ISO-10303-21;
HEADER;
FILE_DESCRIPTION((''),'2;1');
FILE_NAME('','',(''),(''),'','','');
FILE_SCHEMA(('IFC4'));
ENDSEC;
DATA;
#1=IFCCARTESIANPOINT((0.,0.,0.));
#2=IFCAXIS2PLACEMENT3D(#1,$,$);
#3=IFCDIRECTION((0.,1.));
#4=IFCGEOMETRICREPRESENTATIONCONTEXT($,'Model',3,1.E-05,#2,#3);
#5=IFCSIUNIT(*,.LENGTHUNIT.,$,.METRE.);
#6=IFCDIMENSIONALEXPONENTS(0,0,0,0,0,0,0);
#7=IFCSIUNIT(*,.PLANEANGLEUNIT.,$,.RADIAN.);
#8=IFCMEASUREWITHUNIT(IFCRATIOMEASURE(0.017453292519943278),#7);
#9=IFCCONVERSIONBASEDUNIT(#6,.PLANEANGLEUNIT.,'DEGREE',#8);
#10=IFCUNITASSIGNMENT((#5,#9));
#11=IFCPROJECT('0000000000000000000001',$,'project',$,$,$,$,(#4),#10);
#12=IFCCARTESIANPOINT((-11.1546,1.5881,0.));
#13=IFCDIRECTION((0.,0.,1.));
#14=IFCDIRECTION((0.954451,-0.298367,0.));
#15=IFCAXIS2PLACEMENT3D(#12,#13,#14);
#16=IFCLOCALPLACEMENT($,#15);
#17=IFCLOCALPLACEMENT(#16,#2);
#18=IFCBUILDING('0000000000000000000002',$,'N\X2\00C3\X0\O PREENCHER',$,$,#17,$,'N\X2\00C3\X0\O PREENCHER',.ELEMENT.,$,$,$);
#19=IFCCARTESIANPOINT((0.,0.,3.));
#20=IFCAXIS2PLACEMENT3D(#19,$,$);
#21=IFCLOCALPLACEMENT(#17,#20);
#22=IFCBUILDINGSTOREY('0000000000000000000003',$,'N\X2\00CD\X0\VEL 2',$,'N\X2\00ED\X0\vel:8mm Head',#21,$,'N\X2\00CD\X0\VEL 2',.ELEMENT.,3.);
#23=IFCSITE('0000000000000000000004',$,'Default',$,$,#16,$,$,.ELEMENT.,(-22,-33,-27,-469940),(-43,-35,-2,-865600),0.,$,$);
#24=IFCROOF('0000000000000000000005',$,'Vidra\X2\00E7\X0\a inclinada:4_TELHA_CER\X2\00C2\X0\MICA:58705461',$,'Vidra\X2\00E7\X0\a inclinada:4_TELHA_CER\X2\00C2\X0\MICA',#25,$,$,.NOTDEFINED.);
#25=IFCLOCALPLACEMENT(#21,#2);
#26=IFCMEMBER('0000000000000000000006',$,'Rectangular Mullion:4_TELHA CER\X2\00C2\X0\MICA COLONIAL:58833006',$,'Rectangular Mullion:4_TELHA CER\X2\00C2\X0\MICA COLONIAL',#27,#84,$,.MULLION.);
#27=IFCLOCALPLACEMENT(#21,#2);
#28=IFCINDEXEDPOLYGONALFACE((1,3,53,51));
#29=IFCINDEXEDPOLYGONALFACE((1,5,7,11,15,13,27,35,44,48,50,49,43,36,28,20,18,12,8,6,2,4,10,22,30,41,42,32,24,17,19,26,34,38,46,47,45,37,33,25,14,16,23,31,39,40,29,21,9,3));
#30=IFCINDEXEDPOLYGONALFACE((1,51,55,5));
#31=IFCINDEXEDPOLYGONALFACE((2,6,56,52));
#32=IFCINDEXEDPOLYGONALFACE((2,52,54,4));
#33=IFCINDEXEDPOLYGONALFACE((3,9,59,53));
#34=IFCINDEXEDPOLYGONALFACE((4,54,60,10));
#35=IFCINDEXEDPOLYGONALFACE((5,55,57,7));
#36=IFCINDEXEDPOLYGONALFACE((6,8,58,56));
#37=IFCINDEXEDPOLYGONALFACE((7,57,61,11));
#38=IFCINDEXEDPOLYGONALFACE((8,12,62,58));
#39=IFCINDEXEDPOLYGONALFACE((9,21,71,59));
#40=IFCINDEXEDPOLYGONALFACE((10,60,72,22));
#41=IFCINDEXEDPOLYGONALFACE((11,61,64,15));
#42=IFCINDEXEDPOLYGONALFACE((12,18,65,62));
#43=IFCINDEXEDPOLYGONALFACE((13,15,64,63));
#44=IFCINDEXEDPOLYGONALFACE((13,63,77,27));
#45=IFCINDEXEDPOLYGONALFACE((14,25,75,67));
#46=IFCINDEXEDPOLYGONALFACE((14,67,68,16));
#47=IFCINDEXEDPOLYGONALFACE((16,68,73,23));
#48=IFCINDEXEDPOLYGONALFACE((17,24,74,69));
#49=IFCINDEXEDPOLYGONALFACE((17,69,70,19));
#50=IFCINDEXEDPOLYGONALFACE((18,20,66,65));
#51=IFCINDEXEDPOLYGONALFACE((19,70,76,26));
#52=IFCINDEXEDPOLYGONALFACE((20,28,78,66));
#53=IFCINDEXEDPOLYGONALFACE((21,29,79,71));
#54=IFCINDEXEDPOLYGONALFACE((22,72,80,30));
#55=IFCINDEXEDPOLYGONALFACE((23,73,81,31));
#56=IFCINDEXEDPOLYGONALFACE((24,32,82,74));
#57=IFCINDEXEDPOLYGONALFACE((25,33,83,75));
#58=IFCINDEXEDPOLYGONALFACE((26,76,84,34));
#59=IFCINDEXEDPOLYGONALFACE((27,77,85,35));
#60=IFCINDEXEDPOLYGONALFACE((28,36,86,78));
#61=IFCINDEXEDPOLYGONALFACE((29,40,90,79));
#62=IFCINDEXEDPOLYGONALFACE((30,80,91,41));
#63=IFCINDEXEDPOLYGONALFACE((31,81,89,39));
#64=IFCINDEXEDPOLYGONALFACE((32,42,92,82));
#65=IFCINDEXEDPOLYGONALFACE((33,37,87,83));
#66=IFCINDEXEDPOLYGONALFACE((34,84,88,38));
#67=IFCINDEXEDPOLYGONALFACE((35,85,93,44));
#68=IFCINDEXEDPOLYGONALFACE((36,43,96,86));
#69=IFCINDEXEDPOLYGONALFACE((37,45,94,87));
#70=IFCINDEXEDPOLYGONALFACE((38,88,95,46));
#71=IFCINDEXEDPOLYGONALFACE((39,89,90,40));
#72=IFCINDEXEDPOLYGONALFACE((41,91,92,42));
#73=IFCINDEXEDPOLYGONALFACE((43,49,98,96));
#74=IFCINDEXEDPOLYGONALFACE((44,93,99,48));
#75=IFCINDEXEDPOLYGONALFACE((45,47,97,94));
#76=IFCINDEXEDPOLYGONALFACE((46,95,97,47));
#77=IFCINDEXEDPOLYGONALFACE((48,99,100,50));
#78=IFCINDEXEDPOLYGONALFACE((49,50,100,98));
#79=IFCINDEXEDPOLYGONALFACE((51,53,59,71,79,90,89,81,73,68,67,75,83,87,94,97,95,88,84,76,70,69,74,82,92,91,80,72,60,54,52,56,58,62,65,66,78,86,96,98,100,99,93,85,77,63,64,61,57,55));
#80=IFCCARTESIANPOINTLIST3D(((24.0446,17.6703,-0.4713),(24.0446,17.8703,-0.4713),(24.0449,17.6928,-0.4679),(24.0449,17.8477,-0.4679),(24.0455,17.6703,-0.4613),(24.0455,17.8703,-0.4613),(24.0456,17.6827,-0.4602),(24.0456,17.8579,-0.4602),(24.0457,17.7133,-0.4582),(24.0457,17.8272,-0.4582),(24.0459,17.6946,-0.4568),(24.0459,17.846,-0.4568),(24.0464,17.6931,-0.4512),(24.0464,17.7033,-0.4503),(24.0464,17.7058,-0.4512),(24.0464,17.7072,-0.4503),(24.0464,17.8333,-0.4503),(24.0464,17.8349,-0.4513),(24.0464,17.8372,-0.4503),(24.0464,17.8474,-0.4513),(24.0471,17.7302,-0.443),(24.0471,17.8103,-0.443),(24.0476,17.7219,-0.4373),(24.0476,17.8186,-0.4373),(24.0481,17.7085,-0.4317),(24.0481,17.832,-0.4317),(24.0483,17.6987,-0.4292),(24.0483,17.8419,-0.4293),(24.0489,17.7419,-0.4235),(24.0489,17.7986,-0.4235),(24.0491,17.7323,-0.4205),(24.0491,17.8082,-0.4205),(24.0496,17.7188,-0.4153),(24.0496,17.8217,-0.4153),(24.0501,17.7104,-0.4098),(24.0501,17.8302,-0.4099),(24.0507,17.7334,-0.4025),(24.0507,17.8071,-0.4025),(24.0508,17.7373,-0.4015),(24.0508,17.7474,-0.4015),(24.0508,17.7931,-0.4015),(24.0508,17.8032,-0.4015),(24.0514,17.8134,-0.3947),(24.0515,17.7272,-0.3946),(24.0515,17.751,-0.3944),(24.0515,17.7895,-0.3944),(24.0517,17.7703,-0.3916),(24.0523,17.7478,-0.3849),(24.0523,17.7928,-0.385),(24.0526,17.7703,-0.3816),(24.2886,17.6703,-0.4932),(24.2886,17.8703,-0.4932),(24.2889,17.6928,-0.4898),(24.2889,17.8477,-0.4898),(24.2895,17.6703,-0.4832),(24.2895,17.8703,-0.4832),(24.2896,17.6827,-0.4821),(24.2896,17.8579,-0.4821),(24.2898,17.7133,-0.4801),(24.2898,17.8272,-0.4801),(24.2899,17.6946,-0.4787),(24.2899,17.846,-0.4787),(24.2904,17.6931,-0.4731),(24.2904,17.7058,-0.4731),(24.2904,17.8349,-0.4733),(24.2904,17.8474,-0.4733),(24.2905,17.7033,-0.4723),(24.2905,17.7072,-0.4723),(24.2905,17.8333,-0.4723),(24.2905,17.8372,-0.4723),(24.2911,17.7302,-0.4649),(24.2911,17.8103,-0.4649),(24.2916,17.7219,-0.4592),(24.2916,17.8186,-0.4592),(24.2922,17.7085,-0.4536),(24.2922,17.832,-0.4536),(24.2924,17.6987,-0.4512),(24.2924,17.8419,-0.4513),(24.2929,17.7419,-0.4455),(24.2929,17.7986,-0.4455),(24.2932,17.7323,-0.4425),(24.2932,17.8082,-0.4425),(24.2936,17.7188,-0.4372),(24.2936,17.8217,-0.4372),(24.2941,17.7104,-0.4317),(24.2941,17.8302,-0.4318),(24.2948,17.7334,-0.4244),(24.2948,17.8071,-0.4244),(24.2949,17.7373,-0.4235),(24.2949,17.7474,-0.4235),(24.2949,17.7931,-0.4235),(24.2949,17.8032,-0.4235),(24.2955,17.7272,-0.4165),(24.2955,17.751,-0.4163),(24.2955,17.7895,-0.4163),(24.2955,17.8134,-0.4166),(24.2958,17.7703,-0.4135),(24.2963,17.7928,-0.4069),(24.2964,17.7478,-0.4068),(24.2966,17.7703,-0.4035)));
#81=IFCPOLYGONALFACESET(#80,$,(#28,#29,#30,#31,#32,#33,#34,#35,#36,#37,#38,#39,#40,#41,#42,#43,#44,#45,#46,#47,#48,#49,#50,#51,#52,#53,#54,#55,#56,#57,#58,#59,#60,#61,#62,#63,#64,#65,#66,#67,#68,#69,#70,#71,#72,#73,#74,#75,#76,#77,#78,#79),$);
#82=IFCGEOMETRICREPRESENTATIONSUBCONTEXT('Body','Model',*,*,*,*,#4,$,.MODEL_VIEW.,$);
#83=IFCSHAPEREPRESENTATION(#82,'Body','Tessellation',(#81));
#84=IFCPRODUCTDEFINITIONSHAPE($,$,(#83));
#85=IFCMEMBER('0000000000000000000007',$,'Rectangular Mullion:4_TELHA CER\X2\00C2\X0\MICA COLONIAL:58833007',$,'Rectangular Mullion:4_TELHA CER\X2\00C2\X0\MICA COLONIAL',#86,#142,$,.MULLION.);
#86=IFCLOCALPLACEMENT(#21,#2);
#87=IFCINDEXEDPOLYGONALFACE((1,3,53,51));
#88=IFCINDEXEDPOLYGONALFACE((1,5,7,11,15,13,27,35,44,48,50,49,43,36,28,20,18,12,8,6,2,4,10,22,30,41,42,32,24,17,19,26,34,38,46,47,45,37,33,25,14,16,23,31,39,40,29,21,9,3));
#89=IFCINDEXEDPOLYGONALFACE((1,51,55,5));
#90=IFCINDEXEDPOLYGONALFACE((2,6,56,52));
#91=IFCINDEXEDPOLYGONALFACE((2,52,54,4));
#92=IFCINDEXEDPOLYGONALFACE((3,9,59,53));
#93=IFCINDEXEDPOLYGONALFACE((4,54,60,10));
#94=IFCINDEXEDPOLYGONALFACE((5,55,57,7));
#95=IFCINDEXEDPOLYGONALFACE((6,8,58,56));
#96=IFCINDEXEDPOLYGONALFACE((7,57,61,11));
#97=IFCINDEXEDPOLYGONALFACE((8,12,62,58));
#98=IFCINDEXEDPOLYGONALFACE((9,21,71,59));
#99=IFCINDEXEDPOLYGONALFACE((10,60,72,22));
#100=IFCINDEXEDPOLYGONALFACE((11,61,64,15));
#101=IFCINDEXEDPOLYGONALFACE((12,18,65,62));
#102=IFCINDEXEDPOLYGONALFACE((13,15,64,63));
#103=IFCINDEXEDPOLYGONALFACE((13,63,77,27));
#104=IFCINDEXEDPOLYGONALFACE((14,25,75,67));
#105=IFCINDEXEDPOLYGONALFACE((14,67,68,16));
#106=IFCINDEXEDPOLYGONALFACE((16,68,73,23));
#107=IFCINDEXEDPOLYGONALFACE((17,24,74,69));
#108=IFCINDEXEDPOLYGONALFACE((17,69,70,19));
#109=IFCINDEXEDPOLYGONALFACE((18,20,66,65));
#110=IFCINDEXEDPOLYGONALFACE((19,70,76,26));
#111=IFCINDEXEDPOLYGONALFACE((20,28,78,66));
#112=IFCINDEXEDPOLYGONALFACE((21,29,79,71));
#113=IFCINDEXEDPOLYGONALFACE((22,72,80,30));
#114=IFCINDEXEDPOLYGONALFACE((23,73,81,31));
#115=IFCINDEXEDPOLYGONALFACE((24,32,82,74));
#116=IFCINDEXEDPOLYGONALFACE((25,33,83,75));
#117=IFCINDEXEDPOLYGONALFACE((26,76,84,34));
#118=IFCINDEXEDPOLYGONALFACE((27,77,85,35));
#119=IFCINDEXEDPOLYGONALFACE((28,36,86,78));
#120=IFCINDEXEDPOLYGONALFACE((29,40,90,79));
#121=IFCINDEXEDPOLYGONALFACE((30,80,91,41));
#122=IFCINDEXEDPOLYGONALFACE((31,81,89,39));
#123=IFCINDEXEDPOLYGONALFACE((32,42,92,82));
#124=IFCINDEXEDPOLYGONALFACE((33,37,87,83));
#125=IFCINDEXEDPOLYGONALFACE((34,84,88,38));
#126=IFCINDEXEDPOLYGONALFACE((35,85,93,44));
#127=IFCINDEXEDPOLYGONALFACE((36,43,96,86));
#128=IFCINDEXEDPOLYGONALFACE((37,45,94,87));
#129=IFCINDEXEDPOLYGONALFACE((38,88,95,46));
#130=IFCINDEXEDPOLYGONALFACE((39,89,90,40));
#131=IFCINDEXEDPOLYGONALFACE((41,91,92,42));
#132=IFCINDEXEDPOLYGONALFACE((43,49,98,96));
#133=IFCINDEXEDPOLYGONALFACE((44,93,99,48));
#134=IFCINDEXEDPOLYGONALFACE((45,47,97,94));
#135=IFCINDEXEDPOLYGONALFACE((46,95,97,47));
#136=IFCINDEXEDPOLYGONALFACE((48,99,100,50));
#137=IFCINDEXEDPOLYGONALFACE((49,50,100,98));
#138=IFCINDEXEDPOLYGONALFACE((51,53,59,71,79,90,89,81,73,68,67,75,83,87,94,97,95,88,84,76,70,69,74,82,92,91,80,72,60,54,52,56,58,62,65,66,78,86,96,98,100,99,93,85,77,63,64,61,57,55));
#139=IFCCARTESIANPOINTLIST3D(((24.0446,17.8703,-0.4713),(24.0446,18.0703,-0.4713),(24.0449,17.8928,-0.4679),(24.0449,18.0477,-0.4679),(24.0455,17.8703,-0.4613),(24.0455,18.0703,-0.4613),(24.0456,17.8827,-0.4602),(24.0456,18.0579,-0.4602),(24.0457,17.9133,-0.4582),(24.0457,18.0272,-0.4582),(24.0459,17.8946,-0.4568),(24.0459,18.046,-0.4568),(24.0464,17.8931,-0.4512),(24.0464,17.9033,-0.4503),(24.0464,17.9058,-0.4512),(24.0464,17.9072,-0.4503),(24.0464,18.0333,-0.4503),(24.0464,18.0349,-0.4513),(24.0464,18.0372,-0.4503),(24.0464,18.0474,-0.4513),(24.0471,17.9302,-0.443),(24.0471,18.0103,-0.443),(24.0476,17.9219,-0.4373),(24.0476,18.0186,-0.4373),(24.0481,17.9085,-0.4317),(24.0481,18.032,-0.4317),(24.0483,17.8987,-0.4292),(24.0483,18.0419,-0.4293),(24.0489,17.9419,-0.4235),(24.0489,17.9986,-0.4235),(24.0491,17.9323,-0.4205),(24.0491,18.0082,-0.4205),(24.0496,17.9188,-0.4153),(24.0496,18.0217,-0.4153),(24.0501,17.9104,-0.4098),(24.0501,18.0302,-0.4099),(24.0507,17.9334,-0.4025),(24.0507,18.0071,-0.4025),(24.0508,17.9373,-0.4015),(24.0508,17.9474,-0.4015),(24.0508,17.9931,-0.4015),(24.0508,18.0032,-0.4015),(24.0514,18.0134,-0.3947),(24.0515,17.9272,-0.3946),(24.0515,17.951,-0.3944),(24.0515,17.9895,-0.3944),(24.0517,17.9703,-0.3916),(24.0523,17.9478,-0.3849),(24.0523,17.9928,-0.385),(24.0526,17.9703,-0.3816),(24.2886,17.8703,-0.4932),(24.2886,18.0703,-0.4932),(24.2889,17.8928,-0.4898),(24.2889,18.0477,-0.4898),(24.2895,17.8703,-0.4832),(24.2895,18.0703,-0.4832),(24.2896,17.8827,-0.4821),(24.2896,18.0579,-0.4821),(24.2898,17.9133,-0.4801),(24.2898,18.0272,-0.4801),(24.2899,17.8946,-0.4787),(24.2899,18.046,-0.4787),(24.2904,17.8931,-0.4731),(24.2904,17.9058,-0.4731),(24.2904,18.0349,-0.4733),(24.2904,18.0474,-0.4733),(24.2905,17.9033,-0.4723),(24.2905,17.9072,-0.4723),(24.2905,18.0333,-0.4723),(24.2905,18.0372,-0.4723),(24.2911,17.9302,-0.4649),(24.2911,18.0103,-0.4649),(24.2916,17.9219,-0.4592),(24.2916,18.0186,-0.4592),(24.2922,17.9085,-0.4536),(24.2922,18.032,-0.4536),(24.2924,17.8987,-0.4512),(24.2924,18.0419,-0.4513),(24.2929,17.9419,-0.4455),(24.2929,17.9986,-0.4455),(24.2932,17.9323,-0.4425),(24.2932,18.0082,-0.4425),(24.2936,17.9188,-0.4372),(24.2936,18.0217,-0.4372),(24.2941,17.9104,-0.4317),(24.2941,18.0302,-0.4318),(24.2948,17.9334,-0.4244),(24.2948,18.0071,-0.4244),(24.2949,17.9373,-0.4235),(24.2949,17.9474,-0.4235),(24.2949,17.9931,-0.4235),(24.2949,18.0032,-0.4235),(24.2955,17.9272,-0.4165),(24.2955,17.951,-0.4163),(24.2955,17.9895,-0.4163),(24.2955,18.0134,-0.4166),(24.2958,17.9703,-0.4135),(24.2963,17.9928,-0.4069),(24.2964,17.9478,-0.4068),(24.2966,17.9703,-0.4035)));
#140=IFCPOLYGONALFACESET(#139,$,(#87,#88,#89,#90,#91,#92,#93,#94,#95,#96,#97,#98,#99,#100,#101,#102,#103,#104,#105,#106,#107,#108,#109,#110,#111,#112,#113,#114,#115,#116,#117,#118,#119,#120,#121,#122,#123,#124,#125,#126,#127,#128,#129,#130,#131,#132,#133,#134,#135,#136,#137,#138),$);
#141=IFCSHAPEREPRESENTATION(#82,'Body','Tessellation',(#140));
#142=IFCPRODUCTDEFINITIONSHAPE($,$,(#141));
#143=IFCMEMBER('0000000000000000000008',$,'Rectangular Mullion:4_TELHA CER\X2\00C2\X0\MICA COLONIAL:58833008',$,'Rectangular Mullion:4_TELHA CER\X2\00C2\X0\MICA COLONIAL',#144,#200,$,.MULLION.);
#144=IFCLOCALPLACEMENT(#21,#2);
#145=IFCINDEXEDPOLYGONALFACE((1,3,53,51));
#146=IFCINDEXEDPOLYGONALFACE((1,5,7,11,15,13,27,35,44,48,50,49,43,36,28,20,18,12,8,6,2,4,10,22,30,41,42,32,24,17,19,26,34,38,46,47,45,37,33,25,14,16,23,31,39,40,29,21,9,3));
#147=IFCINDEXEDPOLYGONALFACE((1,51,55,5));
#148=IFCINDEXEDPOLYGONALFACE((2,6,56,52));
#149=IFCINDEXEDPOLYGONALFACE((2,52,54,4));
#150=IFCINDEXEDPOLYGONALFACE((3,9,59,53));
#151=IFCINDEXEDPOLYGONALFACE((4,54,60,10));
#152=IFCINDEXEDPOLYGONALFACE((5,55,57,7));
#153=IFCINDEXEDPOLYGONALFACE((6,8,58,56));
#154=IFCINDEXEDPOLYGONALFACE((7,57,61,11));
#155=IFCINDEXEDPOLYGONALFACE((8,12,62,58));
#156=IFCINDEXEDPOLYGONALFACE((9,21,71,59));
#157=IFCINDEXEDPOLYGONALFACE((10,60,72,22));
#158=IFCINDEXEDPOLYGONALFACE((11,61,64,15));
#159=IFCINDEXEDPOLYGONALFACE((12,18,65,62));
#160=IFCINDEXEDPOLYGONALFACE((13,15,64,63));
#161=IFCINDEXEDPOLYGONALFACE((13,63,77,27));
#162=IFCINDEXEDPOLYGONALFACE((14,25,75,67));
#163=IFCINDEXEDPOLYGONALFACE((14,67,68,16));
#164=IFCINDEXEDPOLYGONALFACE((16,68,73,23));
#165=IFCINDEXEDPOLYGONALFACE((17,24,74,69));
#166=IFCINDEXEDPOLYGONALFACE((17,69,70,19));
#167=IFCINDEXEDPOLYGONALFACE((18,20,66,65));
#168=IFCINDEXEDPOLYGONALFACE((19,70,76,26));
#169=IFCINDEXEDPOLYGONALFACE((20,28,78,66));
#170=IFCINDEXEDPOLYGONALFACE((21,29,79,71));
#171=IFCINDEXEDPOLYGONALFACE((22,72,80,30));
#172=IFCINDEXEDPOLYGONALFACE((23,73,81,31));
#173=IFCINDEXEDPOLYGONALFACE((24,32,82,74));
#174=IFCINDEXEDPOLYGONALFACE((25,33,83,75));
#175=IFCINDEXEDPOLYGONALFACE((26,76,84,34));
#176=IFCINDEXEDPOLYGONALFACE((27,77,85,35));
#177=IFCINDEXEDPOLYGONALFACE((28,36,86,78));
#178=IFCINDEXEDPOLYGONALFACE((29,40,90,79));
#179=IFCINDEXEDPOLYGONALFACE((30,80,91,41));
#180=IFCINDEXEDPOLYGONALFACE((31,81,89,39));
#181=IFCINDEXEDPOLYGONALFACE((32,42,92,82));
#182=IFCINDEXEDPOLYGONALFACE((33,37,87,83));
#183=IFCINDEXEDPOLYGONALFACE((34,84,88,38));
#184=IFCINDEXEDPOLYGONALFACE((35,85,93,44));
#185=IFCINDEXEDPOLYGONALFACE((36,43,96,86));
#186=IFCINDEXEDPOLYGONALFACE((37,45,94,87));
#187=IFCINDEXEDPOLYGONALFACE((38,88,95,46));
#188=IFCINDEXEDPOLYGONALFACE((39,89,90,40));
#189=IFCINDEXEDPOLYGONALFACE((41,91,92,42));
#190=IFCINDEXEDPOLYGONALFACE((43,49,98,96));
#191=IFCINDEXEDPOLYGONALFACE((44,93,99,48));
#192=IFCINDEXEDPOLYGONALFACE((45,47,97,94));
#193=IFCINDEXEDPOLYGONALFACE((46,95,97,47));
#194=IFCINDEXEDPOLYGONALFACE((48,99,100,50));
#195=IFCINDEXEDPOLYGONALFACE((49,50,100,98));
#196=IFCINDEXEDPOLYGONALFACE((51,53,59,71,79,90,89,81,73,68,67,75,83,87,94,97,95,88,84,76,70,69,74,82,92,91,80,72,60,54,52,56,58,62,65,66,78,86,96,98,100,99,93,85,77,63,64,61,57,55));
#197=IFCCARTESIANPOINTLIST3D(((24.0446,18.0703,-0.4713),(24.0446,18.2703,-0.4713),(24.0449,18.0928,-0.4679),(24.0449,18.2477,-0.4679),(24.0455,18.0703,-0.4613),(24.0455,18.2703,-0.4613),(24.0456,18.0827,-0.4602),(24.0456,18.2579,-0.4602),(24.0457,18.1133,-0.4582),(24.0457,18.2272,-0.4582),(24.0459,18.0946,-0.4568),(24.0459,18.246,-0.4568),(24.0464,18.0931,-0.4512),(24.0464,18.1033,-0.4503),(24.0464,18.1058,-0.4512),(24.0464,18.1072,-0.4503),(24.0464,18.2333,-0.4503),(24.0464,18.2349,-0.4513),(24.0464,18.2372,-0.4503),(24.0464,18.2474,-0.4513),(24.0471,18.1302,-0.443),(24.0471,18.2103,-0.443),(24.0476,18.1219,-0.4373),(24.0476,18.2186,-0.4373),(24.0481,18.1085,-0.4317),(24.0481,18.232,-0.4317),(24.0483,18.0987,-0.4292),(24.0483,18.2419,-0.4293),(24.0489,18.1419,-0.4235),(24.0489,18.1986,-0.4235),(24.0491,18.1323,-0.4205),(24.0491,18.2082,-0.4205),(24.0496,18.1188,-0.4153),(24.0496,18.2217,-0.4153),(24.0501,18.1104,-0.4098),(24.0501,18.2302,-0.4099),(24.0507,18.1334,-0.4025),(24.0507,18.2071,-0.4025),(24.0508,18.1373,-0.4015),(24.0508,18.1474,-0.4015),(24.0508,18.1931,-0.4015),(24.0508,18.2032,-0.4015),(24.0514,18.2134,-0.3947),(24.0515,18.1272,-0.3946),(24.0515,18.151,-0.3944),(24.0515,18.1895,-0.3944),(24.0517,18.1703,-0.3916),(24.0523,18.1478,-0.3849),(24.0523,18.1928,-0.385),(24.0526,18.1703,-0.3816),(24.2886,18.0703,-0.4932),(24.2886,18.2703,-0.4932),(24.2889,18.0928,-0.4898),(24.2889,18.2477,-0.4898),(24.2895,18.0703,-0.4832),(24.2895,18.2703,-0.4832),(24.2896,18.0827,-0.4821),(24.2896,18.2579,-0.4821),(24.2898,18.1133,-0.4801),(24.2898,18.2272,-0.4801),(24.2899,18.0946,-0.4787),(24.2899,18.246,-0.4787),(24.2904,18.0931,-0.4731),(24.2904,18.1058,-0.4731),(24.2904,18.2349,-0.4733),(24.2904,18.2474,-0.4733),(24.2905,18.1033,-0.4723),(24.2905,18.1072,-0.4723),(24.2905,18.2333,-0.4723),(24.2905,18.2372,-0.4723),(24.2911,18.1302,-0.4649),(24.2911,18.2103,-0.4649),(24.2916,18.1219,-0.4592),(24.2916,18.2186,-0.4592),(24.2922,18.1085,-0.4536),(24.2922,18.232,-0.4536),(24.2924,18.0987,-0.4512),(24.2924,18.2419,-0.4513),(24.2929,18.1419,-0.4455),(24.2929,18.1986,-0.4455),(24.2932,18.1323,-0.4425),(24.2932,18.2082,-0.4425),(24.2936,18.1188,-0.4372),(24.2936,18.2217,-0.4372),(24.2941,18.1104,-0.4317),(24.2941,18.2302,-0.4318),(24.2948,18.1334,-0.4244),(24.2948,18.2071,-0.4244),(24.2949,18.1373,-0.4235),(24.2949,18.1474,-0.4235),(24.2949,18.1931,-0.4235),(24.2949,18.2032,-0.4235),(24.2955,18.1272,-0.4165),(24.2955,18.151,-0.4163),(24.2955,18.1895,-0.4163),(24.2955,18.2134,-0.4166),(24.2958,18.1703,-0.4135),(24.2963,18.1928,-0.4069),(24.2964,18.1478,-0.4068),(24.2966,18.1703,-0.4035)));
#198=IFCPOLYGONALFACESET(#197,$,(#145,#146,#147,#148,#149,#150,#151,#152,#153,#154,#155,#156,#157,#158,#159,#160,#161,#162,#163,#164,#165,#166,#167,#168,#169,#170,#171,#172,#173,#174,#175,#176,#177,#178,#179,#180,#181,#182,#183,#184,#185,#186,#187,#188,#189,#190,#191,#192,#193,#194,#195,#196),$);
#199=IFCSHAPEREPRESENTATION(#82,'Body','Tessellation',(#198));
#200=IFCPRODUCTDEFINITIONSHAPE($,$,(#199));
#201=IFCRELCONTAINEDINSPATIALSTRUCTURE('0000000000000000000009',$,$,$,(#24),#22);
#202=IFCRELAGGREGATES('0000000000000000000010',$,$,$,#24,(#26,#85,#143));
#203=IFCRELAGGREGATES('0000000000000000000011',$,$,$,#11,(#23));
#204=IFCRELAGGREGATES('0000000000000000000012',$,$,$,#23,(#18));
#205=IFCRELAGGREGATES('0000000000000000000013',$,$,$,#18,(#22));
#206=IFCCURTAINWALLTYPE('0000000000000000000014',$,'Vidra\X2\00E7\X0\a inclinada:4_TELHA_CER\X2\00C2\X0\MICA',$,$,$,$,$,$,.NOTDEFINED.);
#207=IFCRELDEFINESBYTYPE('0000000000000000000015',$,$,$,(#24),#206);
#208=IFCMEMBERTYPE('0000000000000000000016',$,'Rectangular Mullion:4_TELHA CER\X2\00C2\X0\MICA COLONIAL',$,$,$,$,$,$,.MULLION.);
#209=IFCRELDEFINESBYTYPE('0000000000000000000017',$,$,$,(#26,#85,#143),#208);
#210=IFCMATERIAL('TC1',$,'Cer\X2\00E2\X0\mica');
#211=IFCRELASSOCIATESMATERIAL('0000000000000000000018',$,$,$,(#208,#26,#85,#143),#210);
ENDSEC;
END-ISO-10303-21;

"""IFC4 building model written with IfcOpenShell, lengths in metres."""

from ifc_helpers import new_model, entity, si_unit, converted_unit, direction, frame, origin, place, context, subcontext, project, spatial, line, arc, indexed_curve, outline, extrude, source, transform, mapped, material, type_object, type_shapes, element, aggregate, save


model = new_model("IFC4")

# Units and contexts
model_context = context("Model", 3, precision=1e-05, world=origin(), true_north=direction((0.0, 1.0)))
body_context = subcontext(model_context, "Body", "Model", "MODEL_VIEW")
ifc_project = project(units=[si_unit("LENGTHUNIT", "METRE"), converted_unit("PLANEANGLEUNIT", "DEGREE", entity("IfcRatioMeasure", 0.017453292519943278), si_unit("PLANEANGLEUNIT", "RADIAN"), dimensions=[0, 0, 0, 0, 0, 0, 0])], contexts=[model_context])

# Site, building, storey
site_placement = place(None, frame((-11.1546, 1.5881, 0.0), z_axis=(0.0, 0.0, 1.0), x_axis=(0.954451, -0.298367, 0.0)))
site = spatial("IfcSite", under=ifc_project, at=site_placement, Name="Default", CompositionType="ELEMENT", RefLatitude=(-22, -33, -27, -469940), RefLongitude=(-43, -35, -2, -865600), RefElevation=0.0)
building_placement = place(site_placement, origin())
building = spatial("IfcBuilding", under=site, at=building_placement, Name="NÃO PREENCHER", LongName="NÃO PREENCHER", CompositionType="ELEMENT")
storey_placement = place(building_placement, frame((0.0, 0.0, 3.0)))
storey = spatial("IfcBuildingStorey", under=building, at=storey_placement, Name="NÍVEL 2", ObjectType="Nível:8mm Head", LongName="NÍVEL 2", CompositionType="ELEMENT", Elevation=3.0)

# Roof, members
curtain_wall_type = type_object("IfcCurtainWallType", Name="Vidraça inclinada:4_TELHA_CERÂMICA", PredefinedType="NOTDEFINED")
roof_placement = place(storey_placement, frame((0.0, 0.0, -3.0)))
roof = element("IfcRoof", 1, at=roof_placement, inside=storey, type_object=curtain_wall_type, Name="Vidraça inclinada:4_TELHA_CERÂMICA:58705461", ObjectType="Vidraça inclinada:4_TELHA_CERÂMICA", PredefinedType="NOTDEFINED")
ifc_material_1 = material(Name="TC1", Category="Cerâmica")
member_type_1 = type_object("IfcMemberType", Name="Rectangular Mullion:4_TELHA CERÂMICA COLONIAL", PredefinedType="MULLION", material=ifc_material_1)
shared_shape_1 = source(origin(), body_context, "Body", "SweptSolid", [
    extrude(outline(indexed_curve([(-0.029, -0.1), (-0.019, -0.1), (-0.0164, -0.0815), (-0.0089, -0.0645), (-0.0089, -0.0771), (0.061, 0.0), (-0.009, 0.0771), (-0.009, 0.0646), (-0.0165, 0.0816), (-0.019, 0.1), (-0.029, 0.1), (-0.0089, 0.0479), (0.041, 0.0229), (0.041, 0.0329), (0.0131, 0.0425), (-0.008, 0.0631), (-0.008, 0.067), (0.051, 0.0), (-0.008, -0.067), (-0.008, -0.0631), (0.0131, -0.0425), (0.041, -0.0329), (0.041, -0.0229), (-0.0089, -0.0479)], segments=[line(1, 2), arc(2, 3, 4), line(4, 5), arc(5, 6, 7), line(7, 8), arc(8, 9, 10), line(10, 11), arc(11, 12, 13), line(13, 14), arc(14, 15, 16), line(16, 17), arc(17, 18, 19), line(19, 20), arc(20, 21, 22), line(22, 23), arc(23, 24, 1)], self_intersect=False)), frame((0.0, -0.029, -0.245), z_axis=(0.0, 0.0, 1.0), x_axis=(0.0, -1.0, 0.0)), (0.0, 0.0, 1.0), 0.245),
])
type_shapes(member_type_1, [shared_shape_1])
member_1_placement = place(roof_placement, frame((24.0446, 17.7703, 2.5287), z_axis=(-0.99599, 0.0, 0.089469), x_axis=(0.0, 1.0, 0.0)))
member_1 = element("IfcMember", 2, at=member_1_placement, type_object=member_type_1, material=ifc_material_1, Name="Rectangular Mullion:4_TELHA CERÂMICA COLONIAL:58833006", ObjectType="Rectangular Mullion:4_TELHA CERÂMICA COLONIAL", PredefinedType="MULLION", context=body_context, shape_type="MappedRepresentation", body=[
    mapped(shared_shape_1, transform((0.0, 0.0, 0.0), scale=1.0)),
])
member_2_placement = place(roof_placement, frame((24.0446, 17.9703, 2.5287), z_axis=(-0.99599, 0.0, 0.089469), x_axis=(0.0, 1.0, 0.0)))
member_2 = element("IfcMember", 3, at=member_2_placement, type_object=member_type_1, material=ifc_material_1, Name="Rectangular Mullion:4_TELHA CERÂMICA COLONIAL:58833007", ObjectType="Rectangular Mullion:4_TELHA CERÂMICA COLONIAL", PredefinedType="MULLION", context=body_context, shape_type="MappedRepresentation", body=[
    mapped(shared_shape_1, transform((0.0, 0.0, 0.0), scale=1.0)),
])
member_3_placement = place(roof_placement, frame((24.0446, 18.1703, 2.5287), z_axis=(-0.99599, 0.0, 0.089469), x_axis=(0.0, 1.0, 0.0)))
member_3 = element("IfcMember", 4, at=member_3_placement, type_object=member_type_1, material=ifc_material_1, Name="Rectangular Mullion:4_TELHA CERÂMICA COLONIAL:58833008", ObjectType="Rectangular Mullion:4_TELHA CERÂMICA COLONIAL", PredefinedType="MULLION", context=body_context, shape_type="MappedRepresentation", body=[
    mapped(shared_shape_1, transform((0.0, 0.0, 0.0), scale=1.0)),
])
aggregate(roof, [member_1, member_2, member_3])

save(model, "model.ifc")
